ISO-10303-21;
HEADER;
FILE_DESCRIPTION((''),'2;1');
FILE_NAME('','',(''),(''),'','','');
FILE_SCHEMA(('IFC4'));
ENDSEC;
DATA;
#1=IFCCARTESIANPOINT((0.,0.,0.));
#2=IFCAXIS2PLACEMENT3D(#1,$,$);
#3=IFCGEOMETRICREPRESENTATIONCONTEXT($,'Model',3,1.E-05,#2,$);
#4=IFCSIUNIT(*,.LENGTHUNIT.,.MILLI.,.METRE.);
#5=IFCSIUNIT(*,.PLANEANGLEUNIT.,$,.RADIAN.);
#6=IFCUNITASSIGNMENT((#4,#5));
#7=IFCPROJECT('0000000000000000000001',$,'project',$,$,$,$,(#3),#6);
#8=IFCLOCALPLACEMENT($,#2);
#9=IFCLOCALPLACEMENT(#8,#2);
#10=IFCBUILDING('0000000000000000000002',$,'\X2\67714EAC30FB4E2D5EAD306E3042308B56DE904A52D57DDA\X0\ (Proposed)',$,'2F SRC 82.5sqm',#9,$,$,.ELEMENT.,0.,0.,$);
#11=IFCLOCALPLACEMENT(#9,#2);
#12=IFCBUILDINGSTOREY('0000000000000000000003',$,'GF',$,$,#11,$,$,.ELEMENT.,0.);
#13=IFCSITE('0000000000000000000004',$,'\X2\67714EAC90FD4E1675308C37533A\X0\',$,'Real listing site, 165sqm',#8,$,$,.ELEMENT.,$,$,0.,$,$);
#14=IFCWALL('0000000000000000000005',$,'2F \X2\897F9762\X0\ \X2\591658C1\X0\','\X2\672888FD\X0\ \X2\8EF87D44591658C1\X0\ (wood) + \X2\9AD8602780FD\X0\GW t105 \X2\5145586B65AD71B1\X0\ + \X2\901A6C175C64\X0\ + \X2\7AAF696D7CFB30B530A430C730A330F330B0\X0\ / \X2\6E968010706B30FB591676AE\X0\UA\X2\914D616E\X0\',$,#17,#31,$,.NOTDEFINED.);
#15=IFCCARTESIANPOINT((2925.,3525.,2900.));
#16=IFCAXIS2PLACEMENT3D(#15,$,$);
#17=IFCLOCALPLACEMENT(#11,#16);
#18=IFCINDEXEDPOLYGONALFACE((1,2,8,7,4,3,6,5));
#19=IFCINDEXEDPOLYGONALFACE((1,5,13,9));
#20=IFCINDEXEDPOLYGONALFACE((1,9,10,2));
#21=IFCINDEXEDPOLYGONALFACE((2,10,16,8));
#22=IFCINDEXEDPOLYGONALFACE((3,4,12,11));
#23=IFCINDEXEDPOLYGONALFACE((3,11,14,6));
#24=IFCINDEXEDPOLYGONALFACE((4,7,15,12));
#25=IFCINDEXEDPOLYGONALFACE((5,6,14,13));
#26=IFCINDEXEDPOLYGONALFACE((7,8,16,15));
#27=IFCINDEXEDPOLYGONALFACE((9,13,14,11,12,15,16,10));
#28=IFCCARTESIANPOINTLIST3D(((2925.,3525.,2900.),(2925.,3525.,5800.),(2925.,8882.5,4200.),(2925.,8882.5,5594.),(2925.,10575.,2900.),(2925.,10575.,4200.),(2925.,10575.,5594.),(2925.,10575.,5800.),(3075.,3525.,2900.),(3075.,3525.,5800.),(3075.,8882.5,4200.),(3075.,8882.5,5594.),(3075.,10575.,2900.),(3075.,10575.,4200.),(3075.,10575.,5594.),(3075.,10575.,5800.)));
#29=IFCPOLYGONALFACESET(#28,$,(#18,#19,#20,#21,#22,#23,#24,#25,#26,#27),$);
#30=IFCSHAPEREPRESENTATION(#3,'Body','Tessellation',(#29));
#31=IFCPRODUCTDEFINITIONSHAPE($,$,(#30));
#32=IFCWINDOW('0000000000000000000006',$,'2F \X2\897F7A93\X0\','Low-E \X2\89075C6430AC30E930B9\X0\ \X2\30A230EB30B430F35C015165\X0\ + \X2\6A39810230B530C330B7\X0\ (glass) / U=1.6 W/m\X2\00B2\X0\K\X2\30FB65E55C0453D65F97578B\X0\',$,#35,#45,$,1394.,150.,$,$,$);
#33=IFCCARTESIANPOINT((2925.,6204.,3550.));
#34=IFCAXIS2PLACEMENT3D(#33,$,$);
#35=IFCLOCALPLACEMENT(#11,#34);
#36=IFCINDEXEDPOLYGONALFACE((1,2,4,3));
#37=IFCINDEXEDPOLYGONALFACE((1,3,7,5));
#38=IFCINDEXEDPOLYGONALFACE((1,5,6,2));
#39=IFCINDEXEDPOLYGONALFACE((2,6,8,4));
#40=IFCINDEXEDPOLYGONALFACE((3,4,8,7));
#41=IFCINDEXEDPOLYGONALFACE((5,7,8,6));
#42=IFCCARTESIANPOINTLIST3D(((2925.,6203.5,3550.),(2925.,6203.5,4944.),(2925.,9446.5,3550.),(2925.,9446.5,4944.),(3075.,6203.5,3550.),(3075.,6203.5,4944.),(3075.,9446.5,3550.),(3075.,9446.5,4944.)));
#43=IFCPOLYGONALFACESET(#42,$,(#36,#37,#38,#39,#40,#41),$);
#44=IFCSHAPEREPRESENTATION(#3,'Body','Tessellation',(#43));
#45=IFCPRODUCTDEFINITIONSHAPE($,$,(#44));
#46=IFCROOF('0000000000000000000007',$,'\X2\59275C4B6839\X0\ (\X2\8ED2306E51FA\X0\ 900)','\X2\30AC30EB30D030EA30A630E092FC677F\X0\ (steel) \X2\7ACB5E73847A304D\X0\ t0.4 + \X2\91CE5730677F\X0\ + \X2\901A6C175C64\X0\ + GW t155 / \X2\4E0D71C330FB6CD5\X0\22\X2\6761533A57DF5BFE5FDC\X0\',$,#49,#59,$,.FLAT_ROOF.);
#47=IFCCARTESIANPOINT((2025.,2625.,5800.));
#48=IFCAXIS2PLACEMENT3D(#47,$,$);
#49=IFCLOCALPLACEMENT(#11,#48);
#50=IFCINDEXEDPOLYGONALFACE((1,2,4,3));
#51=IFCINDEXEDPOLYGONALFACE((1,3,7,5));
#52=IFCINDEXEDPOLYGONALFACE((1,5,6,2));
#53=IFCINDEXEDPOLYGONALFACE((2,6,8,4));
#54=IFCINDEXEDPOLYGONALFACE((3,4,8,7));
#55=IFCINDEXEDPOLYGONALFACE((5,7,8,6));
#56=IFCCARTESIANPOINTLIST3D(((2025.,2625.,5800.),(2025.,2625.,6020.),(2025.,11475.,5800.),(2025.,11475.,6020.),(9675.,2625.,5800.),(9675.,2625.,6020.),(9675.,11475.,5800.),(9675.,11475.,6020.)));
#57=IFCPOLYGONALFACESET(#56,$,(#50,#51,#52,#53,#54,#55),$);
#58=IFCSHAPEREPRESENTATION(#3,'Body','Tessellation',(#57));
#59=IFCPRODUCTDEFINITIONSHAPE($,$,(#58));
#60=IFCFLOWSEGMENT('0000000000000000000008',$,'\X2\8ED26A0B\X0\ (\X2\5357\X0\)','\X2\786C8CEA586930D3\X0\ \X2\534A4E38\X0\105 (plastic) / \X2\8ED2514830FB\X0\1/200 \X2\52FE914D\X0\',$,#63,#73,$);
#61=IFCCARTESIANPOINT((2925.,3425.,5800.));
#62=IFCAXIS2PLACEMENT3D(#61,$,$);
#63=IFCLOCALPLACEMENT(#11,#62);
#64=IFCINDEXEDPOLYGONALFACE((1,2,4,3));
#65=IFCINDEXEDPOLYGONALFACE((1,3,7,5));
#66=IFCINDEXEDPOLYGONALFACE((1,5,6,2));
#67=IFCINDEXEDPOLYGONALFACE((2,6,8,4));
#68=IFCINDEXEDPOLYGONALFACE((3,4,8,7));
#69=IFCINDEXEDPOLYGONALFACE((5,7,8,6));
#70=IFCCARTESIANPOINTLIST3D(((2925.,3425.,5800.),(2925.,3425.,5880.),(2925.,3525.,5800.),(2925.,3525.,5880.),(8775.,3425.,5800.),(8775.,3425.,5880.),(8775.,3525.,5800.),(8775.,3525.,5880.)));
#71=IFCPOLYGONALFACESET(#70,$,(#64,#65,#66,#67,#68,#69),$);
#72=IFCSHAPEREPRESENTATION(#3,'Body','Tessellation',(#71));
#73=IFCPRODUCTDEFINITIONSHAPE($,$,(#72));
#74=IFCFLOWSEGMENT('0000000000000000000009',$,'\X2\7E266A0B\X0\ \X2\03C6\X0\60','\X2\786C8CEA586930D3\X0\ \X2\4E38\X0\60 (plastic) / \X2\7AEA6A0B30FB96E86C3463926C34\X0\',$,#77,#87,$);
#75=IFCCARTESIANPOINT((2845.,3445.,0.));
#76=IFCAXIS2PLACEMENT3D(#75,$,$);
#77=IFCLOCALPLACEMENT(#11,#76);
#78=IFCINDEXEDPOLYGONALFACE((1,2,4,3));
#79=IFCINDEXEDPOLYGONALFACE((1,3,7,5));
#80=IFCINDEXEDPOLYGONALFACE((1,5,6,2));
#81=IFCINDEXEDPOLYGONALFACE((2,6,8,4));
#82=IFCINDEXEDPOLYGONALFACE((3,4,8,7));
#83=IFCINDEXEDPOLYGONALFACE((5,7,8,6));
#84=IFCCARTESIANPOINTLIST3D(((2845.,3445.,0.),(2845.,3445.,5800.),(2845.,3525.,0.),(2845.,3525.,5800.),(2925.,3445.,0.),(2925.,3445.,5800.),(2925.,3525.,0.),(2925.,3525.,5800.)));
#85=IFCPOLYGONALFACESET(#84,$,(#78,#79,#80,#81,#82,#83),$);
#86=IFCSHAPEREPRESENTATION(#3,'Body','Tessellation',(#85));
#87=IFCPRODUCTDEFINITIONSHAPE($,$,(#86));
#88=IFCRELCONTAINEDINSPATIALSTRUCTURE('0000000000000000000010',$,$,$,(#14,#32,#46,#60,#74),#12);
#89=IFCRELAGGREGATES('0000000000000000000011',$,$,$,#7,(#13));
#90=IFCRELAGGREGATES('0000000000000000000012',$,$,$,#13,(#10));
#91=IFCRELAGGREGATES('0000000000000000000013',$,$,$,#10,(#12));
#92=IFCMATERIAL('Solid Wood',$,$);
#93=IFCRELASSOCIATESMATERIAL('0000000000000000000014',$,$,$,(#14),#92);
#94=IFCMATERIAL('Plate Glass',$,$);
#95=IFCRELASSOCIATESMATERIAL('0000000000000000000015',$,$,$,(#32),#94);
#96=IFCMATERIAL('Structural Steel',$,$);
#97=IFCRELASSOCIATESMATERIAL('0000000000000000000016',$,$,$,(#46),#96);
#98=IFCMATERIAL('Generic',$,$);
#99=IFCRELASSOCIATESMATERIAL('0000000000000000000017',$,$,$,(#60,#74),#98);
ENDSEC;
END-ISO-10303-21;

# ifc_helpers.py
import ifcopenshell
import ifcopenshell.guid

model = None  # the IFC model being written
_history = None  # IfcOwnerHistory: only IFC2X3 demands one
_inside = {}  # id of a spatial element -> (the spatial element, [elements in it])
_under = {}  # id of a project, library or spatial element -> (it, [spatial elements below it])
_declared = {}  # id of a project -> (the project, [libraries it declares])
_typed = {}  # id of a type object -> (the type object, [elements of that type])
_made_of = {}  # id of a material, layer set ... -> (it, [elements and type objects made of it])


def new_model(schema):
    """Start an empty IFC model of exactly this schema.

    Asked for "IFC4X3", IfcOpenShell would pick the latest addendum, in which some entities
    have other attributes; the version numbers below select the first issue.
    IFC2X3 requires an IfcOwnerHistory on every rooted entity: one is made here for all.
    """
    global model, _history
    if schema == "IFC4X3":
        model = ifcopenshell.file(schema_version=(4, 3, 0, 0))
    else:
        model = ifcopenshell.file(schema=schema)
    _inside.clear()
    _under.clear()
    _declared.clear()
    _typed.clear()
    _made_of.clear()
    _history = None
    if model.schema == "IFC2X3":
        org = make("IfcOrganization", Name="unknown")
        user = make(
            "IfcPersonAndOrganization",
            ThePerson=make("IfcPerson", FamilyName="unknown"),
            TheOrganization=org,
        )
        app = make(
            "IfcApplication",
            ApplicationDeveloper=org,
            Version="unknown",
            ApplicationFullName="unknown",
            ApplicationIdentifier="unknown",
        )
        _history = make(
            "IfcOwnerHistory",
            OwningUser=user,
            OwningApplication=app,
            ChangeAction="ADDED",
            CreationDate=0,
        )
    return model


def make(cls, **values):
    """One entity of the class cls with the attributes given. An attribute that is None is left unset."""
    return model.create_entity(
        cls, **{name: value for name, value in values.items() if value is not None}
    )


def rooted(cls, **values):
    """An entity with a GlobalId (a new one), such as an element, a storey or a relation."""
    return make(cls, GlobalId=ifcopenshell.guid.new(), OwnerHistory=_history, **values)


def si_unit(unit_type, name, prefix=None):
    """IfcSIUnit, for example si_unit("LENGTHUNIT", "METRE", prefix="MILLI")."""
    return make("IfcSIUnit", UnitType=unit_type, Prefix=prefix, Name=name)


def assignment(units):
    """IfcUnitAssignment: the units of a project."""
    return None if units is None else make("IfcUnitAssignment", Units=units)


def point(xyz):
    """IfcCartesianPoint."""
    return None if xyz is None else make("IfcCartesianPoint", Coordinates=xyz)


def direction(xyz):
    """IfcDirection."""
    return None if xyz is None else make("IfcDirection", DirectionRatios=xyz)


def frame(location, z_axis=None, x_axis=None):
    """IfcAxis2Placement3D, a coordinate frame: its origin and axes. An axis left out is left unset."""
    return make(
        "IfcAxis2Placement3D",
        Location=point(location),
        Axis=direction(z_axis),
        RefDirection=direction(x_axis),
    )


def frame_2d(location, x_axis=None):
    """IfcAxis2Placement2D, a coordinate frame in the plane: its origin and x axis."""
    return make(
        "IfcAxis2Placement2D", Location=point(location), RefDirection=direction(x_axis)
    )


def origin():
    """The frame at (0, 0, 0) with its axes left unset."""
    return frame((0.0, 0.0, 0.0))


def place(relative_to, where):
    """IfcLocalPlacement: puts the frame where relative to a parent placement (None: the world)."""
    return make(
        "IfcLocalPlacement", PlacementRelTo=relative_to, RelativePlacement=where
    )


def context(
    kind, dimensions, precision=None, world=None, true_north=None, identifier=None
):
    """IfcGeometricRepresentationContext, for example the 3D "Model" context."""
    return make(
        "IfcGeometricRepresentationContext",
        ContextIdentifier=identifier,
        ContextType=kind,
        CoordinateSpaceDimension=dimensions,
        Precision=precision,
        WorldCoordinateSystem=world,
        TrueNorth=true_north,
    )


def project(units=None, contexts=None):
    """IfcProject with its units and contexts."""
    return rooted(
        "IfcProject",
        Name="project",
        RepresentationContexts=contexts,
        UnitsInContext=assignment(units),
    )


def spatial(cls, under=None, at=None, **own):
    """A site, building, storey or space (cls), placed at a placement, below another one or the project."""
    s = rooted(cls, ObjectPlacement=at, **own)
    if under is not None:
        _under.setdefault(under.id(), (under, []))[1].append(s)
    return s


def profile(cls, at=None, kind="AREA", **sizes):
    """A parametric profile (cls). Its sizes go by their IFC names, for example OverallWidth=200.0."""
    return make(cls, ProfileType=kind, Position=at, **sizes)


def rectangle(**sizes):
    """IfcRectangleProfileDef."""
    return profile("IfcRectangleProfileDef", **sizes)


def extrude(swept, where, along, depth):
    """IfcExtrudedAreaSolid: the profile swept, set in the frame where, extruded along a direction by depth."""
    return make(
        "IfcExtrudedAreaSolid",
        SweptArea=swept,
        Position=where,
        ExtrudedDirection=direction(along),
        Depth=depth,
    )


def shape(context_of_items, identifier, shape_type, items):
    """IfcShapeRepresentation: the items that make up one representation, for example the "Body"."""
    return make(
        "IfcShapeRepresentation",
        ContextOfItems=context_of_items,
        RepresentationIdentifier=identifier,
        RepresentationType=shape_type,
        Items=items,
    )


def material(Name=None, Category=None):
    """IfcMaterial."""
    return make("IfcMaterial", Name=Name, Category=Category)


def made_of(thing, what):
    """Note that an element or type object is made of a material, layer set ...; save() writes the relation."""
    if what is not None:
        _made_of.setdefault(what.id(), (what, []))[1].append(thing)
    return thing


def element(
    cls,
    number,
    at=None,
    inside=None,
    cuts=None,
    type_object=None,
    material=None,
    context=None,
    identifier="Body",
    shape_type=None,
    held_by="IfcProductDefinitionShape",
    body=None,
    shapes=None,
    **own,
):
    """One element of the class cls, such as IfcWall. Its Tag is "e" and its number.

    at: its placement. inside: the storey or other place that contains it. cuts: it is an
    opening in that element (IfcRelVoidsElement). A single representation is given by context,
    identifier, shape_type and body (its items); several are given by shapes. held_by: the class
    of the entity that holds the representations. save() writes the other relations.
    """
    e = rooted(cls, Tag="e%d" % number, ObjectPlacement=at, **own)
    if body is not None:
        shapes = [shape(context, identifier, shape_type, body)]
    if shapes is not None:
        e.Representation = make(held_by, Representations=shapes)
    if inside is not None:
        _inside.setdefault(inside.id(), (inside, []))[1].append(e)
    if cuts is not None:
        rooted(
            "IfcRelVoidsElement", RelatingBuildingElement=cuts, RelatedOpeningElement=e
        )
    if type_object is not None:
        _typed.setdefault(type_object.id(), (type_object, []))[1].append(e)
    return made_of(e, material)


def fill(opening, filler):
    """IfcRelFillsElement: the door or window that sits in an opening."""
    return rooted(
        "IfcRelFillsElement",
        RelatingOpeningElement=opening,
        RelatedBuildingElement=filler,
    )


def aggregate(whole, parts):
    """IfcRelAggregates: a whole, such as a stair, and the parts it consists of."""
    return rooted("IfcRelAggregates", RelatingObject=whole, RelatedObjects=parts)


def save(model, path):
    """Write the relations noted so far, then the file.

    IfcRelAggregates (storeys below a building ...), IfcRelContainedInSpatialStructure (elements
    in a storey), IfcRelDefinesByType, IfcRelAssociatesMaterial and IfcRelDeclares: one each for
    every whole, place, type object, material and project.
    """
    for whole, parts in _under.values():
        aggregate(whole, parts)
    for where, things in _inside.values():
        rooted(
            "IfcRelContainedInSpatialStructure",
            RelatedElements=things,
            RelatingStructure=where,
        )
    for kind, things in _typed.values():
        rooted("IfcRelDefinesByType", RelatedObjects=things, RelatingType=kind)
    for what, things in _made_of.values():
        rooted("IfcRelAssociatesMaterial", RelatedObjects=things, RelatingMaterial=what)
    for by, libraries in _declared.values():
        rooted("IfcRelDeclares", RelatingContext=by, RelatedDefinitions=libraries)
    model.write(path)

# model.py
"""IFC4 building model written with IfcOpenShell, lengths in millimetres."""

from ifc_helpers import new_model, si_unit, frame, frame_2d, origin, place, context, project, spatial, rectangle, extrude, material, element, fill, save


model = new_model("IFC4")

# Units and contexts
model_context = context("Model", 3, precision=1e-05, world=origin())
ifc_project = project(units=[si_unit("LENGTHUNIT", "METRE", prefix="MILLI"), si_unit("PLANEANGLEUNIT", "RADIAN")], contexts=[model_context])

# Site, building, storey
site_placement = place(None, origin())
site = spatial("IfcSite", under=ifc_project, at=site_placement, Name="東京都世田谷区", ObjectType="Real listing site, 165sqm", CompositionType="ELEMENT", RefElevation=0.0)
building_placement = place(site_placement, origin())
building = spatial("IfcBuilding", under=site, at=building_placement, Name="東京・中庭のある回遊動線 (Proposed)", ObjectType="2F SRC 82.5sqm", CompositionType="ELEMENT", ElevationOfRefHeight=0.0, ElevationOfTerrain=0.0)
storey_placement = place(building_placement, origin())
storey = spatial("IfcBuildingStorey", under=building, at=storey_placement, Name="GF", CompositionType="ELEMENT", Elevation=0.0)

# Shared definitions
ifc_material_1 = material(Name="Solid Wood")

# Shared definitions
ifc_material_2 = material(Name="Plate Glass")

# Wall, opening, window
wall_1_placement = place(storey_placement, frame((2925.0, 3525.0, 2900.0)))
wall_1 = element("IfcWall", 1, at=wall_1_placement, inside=storey, material=ifc_material_1, Name="2F 西面 外壁", Description="木製 軸組外壁 (wood) + 高性能GW t105 充填断熱 + 通気層 + 窯業系サイディング / 準耐火・外皮UA配慮", PredefinedType="NOTDEFINED", context=model_context, shape_type="SweptSolid", body=[
    extrude(rectangle(XDim=150.0, YDim=7050.0, at=frame_2d((75.0, 3525.0))), frame((2925.0, 3525.0, 2900.0)), (0.0, 0.0, 1.0), 2900.0),
])
opening_1_placement = place(storey_placement, frame((2925.0, 6204.0, 3550.0)))
opening_1 = element("IfcOpeningElement", 2, at=opening_1_placement, cuts=wall_1, PredefinedType="NOTDEFINED", context=model_context, shape_type="SweptSolid", body=[
    extrude(rectangle(XDim=150.0, YDim=3243.0, at=frame_2d((75.0, 1621.0))), frame((2925.0, 6204.0, 3550.0)), (0.0, 0.0, 1.0), 1394.0),
])
window_1_placement = place(storey_placement, frame((2925.0, 6204.0, 3550.0)))
window_1 = element("IfcWindow", 3, at=window_1_placement, inside=storey, material=ifc_material_2, Name="2F 西窓", Description="Low-E 複層ガラス アルゴン封入 + 樹脂サッシ (glass) / U=1.6 W/m²K・日射取得型", OverallHeight=1394.0, OverallWidth=150.0, context=model_context, shape_type="SweptSolid", body=[
    extrude(rectangle(XDim=150.0, YDim=3243.0, at=frame_2d((75.0, 1621.0))), frame((2925.0, 6204.0, 3550.0)), (0.0, 0.0, 1.0), 1394.0),
])
fill(opening_1, window_1)

# Roof
ifc_material_3 = material(Name="Structural Steel")
roof_placement = place(storey_placement, frame((2025.0, 2625.0, 5800.0)))
element("IfcRoof", 4, at=roof_placement, inside=storey, material=ifc_material_3, Name="大屋根 (軒の出 900)", Description="ガルバリウム鋼板 (steel) 立平葺き t0.4 + 野地板 + 通気層 + GW t155 / 不燃・法22条区域対応", PredefinedType="FLAT_ROOF", context=model_context, shape_type="SweptSolid", body=[
    extrude(rectangle(XDim=7650.0, YDim=8850.0, at=frame_2d((3825.0, 4425.0))), frame((2025.0, 2625.0, 5800.0)), (0.0, 0.0, 1.0), 220.0),
])

# Flow segments
ifc_material_4 = material(Name="Generic")
flow_segment_1_placement = place(storey_placement, frame((2925.0, 3425.0, 5800.0)))
element("IfcFlowSegment", 5, at=flow_segment_1_placement, inside=storey, material=ifc_material_4, Name="軒樋 (南)", Description="硬質塩ビ 半丸105 (plastic) / 軒先・1/200 勾配", context=model_context, shape_type="SweptSolid", body=[
    extrude(rectangle(XDim=5850.0, YDim=100.0, at=frame_2d((2925.0, 50.0))), frame((2925.0, 3425.0, 5800.0)), (0.0, 0.0, 1.0), 80.0),
])
flow_segment_2_placement = place(storey_placement, frame((2845.0, 3445.0, 0.0)))
element("IfcFlowSegment", 6, at=flow_segment_2_placement, inside=storey, material=ifc_material_4, Name="縦樋 φ60", Description="硬質塩ビ 丸60 (plastic) / 竪樋・雨水排水", context=model_context, shape_type="SweptSolid", body=[
    extrude(rectangle(XDim=80.0, YDim=80.0, at=frame_2d((40.0, 40.0))), frame((2845.0, 3445.0, 0.0)), (0.0, 0.0, 1.0), 5800.0),
])

save(model, "model.ifc")
